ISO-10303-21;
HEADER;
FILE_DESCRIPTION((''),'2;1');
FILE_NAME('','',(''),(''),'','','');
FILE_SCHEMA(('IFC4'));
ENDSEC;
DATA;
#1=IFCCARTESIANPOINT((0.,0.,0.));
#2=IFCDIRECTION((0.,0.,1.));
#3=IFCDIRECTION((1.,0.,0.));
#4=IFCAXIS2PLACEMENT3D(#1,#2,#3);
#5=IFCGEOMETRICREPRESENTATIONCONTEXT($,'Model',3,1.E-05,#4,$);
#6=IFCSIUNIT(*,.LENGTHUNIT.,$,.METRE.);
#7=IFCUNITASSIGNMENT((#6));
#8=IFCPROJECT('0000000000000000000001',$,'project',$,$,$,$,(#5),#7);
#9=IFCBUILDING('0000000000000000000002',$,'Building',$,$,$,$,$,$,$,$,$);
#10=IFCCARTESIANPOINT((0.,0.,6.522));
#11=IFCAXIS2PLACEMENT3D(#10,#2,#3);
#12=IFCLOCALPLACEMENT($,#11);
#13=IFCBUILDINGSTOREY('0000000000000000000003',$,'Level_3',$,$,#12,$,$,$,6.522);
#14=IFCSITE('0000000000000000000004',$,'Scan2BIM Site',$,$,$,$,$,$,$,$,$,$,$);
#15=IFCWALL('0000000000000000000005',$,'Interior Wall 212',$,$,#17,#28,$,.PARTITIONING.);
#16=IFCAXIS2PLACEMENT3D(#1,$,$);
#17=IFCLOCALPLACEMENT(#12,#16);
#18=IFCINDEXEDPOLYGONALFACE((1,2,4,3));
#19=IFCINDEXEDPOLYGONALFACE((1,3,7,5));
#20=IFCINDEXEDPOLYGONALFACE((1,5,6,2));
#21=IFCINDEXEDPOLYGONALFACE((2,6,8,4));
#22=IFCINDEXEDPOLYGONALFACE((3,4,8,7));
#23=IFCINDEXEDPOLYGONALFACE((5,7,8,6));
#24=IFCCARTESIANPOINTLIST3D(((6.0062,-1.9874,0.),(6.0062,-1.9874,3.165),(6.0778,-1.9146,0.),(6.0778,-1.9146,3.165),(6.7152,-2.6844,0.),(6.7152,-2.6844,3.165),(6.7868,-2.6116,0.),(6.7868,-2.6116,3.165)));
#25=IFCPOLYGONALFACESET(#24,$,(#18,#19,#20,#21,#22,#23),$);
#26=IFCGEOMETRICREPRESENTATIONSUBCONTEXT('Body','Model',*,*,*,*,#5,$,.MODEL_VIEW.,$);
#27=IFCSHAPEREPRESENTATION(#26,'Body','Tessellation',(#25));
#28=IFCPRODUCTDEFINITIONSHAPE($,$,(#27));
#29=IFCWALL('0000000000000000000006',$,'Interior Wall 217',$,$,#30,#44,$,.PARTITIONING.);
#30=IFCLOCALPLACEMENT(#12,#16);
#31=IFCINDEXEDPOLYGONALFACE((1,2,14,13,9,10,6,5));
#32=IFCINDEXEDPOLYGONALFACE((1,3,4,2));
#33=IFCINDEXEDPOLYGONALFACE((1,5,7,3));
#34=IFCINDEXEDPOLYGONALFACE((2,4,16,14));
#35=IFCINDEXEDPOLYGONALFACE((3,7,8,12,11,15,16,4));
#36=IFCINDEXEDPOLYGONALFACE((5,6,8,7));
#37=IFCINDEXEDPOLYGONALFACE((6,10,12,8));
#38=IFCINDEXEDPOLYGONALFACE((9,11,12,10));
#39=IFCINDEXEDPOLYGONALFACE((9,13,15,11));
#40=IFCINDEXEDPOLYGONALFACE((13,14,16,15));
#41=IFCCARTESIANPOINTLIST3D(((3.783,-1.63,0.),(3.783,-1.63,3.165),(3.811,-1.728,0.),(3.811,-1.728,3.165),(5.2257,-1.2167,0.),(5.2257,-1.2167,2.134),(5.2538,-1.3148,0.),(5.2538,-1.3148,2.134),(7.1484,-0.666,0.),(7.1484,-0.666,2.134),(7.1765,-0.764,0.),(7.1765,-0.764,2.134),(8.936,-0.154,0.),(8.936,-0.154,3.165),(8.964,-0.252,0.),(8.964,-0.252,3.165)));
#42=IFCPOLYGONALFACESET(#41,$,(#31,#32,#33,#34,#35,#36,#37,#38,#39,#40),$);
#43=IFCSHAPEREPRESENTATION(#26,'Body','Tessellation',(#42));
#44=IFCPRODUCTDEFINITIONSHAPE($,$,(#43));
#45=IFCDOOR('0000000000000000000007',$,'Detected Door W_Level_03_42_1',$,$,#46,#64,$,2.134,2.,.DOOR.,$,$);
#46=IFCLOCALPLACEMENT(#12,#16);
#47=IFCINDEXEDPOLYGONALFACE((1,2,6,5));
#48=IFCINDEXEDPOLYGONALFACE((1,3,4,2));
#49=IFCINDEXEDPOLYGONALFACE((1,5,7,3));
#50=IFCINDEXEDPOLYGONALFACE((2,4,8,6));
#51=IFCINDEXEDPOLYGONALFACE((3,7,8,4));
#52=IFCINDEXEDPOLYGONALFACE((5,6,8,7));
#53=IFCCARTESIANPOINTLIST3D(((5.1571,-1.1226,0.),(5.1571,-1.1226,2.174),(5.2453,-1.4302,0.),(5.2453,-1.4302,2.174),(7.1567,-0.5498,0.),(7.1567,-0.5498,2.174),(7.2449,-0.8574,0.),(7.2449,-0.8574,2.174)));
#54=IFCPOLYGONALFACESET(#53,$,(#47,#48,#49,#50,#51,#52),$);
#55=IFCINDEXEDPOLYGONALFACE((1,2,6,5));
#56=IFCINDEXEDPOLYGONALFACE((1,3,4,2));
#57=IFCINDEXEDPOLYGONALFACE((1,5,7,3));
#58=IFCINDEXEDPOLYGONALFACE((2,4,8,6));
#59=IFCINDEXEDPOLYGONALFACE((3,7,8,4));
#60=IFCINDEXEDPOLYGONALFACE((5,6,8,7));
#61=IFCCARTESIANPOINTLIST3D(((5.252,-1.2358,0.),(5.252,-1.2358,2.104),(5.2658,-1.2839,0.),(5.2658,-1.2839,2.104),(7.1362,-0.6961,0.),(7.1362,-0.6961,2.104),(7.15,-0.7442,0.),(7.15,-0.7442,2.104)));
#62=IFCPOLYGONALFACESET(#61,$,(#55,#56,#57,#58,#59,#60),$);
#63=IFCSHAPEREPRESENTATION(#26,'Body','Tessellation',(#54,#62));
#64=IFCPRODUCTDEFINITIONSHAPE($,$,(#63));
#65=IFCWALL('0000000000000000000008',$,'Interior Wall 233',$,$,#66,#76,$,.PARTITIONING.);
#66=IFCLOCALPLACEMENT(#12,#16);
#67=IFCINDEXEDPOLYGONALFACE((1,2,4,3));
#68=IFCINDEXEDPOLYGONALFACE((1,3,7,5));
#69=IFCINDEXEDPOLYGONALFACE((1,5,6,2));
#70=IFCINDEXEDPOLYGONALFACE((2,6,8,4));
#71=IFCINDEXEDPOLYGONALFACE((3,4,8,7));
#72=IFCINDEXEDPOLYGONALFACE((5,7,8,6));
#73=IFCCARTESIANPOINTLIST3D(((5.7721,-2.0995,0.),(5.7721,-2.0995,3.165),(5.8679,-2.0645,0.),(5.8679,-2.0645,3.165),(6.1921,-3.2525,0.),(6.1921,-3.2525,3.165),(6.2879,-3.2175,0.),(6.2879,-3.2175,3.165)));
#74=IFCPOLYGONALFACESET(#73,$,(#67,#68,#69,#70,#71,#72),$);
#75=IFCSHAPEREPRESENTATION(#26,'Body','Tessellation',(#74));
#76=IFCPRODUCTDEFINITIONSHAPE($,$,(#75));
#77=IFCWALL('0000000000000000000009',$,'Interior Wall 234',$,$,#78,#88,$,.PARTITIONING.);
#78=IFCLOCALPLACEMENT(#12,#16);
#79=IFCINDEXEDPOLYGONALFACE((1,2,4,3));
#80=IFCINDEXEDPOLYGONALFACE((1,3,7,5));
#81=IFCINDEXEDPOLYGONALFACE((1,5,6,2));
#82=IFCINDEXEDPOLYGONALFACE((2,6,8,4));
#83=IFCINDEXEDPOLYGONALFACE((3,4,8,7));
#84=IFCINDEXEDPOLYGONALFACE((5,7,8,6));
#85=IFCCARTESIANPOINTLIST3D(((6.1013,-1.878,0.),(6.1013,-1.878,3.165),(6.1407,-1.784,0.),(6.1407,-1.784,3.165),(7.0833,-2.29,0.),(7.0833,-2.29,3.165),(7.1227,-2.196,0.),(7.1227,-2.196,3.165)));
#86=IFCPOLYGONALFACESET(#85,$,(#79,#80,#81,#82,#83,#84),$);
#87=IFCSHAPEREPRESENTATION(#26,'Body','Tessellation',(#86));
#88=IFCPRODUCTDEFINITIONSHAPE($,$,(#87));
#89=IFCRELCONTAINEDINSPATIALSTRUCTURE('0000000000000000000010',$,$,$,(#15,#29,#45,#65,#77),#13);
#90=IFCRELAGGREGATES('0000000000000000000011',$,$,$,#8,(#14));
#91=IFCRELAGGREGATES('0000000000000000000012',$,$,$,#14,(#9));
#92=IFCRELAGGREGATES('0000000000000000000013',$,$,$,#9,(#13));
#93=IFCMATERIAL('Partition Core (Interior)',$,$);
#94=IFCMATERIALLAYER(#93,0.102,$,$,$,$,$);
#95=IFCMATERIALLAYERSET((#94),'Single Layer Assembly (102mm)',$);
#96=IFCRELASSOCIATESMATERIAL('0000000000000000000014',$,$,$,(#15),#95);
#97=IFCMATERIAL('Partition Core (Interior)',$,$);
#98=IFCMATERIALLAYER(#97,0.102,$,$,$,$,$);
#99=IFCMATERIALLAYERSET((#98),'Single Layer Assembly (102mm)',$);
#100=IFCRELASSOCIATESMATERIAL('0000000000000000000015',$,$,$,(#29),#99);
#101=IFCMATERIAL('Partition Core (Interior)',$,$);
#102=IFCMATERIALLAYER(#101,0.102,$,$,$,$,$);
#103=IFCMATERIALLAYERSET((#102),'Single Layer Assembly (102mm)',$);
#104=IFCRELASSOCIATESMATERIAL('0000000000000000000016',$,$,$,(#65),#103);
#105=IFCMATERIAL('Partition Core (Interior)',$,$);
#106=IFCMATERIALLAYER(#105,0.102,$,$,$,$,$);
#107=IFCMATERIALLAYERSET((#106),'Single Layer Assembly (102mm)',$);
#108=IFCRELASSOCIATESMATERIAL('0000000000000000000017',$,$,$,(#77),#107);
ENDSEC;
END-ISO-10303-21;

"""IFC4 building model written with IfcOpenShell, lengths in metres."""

from ifc_helpers import new_model, si_unit, frame, origin, origin_with_axes, place, context, subcontext, project, spatial, rectangle, extrude, material, layer, layer_set, element, fill, save


model = new_model("IFC4")

# Units and contexts
model_context = context("Model", 3, precision=1e-05, world=origin_with_axes())
body_context = subcontext(model_context, "Body", "Model", "MODEL_VIEW")
ifc_project = project(units=[si_unit("LENGTHUNIT", "METRE")], contexts=[model_context])

# Site, building, storey
site = spatial("IfcSite", under=ifc_project, Name="Scan2BIM Site")
building = spatial("IfcBuilding", under=site, Name="Building")
storey_placement = place(None, frame((0.0, 0.0, 6.522), z_axis=(0.0, 0.0, 1.0), x_axis=(1.0, 0.0, 0.0)))
storey = spatial("IfcBuildingStorey", under=building, at=storey_placement, Name="Level_3", Elevation=6.522)

# Wall
ifc_material_1 = material(Name="Partition Core (Interior)")
ifc_layer_1 = layer(ifc_material_1, 0.102)
ifc_layer_set_1 = layer_set([ifc_layer_1], Name="Single Layer Assembly (102mm)")
wall_1_placement = place(storey_placement, frame((6.3965, -2.2995, 0.0), z_axis=(0.0, 0.0, 1.0), x_axis=(-0.713116, 0.701046, 0.0)))
element("IfcWall", 1, at=wall_1_placement, inside=storey, material=ifc_layer_set_1, Name="Interior Wall 212", PredefinedType="PARTITIONING", context=body_context, shape_type="SweptSolid", body=[
    extrude(rectangle(XDim=0.9942, YDim=0.102), origin(), (0.0, 0.0, 1.0), 3.165),
])

# Wall, opening, door
ifc_material_2 = material(Name="Partition Core (Interior)")
ifc_layer_2 = layer(ifc_material_2, 0.102)
ifc_layer_set_2 = layer_set([ifc_layer_2], Name="Single Layer Assembly (102mm)")
wall_2_placement = place(storey_placement, frame((6.3735, -0.941, 0.0), z_axis=(0.0, 0.0, 1.0), x_axis=(0.961341, 0.275362, 0.0)))
wall_2 = element("IfcWall", 2, at=wall_2_placement, inside=storey, material=ifc_layer_set_2, Name="Interior Wall 217", PredefinedType="PARTITIONING", context=body_context, shape_type="SweptSolid", body=[
    extrude(rectangle(XDim=5.3602, YDim=0.102), origin(), (0.0, 0.0, 1.0), 3.165),
])
opening_1_placement = place(None, frame((6.201, -0.99, 6.522), z_axis=(0.0, 0.0, 1.0), x_axis=(0.961341, 0.275362, 0.0)))
opening_1 = element("IfcOpeningElement", 3, at=opening_1_placement, cuts=wall_2, PredefinedType="OPENING", context=body_context, shape_type="SweptSolid", body=[
    extrude(rectangle(XDim=2.0, YDim=0.202), origin(), (0.0, 0.0, 1.0), 2.134),
])
door_1_placement = place(opening_1_placement, frame((0.0, 0.0, 0.0), z_axis=(0.0, 0.0, 1.0), x_axis=(1.0, 0.0, 0.0)))
door_1 = element("IfcDoor", 4, at=door_1_placement, inside=storey, Name="Detected Door W_Level_03_42_1", OverallHeight=2.134, OverallWidth=2.0, PredefinedType="DOOR", context=body_context, shape_type="SweptSolid", body=[
    extrude(rectangle(XDim=2.08, YDim=0.32), origin(), (0.0, 0.0, 1.0), 2.174),
    extrude(rectangle(XDim=1.96, YDim=0.05), origin(), (0.0, 0.0, 1.0), 2.104),
])
fill(opening_1, door_1)

# Walls
ifc_material_3 = material(Name="Partition Core (Interior)")
ifc_layer_3 = layer(ifc_material_3, 0.102)
ifc_layer_set_3 = layer_set([ifc_layer_3], Name="Single Layer Assembly (102mm)")
wall_3_placement = place(storey_placement, frame((6.03, -2.6585, 0.0), z_axis=(0.0, 0.0, 1.0), x_axis=(0.342266, -0.939603, 0.0)))
element("IfcWall", 5, at=wall_3_placement, inside=storey, material=ifc_layer_set_3, Name="Interior Wall 233", PredefinedType="PARTITIONING", context=body_context, shape_type="SweptSolid", body=[
    extrude(rectangle(XDim=1.2271, YDim=0.102), origin(), (0.0, 0.0, 1.0), 3.165),
])
ifc_material_4 = material(Name="Partition Core (Interior)")
ifc_layer_4 = layer(ifc_material_4, 0.102)
ifc_layer_set_4 = layer_set([ifc_layer_4], Name="Single Layer Assembly (102mm)")
wall_4_placement = place(storey_placement, frame((6.612, -2.037, 0.0), z_axis=(0.0, 0.0, 1.0), x_axis=(-0.92213, 0.386881, 0.0)))
element("IfcWall", 6, at=wall_4_placement, inside=storey, material=ifc_layer_set_4, Name="Interior Wall 234", PredefinedType="PARTITIONING", context=body_context, shape_type="SweptSolid", body=[
    extrude(rectangle(XDim=1.0649, YDim=0.102), origin(), (0.0, 0.0, 1.0), 3.165),
])

save(model, "model.ifc")
